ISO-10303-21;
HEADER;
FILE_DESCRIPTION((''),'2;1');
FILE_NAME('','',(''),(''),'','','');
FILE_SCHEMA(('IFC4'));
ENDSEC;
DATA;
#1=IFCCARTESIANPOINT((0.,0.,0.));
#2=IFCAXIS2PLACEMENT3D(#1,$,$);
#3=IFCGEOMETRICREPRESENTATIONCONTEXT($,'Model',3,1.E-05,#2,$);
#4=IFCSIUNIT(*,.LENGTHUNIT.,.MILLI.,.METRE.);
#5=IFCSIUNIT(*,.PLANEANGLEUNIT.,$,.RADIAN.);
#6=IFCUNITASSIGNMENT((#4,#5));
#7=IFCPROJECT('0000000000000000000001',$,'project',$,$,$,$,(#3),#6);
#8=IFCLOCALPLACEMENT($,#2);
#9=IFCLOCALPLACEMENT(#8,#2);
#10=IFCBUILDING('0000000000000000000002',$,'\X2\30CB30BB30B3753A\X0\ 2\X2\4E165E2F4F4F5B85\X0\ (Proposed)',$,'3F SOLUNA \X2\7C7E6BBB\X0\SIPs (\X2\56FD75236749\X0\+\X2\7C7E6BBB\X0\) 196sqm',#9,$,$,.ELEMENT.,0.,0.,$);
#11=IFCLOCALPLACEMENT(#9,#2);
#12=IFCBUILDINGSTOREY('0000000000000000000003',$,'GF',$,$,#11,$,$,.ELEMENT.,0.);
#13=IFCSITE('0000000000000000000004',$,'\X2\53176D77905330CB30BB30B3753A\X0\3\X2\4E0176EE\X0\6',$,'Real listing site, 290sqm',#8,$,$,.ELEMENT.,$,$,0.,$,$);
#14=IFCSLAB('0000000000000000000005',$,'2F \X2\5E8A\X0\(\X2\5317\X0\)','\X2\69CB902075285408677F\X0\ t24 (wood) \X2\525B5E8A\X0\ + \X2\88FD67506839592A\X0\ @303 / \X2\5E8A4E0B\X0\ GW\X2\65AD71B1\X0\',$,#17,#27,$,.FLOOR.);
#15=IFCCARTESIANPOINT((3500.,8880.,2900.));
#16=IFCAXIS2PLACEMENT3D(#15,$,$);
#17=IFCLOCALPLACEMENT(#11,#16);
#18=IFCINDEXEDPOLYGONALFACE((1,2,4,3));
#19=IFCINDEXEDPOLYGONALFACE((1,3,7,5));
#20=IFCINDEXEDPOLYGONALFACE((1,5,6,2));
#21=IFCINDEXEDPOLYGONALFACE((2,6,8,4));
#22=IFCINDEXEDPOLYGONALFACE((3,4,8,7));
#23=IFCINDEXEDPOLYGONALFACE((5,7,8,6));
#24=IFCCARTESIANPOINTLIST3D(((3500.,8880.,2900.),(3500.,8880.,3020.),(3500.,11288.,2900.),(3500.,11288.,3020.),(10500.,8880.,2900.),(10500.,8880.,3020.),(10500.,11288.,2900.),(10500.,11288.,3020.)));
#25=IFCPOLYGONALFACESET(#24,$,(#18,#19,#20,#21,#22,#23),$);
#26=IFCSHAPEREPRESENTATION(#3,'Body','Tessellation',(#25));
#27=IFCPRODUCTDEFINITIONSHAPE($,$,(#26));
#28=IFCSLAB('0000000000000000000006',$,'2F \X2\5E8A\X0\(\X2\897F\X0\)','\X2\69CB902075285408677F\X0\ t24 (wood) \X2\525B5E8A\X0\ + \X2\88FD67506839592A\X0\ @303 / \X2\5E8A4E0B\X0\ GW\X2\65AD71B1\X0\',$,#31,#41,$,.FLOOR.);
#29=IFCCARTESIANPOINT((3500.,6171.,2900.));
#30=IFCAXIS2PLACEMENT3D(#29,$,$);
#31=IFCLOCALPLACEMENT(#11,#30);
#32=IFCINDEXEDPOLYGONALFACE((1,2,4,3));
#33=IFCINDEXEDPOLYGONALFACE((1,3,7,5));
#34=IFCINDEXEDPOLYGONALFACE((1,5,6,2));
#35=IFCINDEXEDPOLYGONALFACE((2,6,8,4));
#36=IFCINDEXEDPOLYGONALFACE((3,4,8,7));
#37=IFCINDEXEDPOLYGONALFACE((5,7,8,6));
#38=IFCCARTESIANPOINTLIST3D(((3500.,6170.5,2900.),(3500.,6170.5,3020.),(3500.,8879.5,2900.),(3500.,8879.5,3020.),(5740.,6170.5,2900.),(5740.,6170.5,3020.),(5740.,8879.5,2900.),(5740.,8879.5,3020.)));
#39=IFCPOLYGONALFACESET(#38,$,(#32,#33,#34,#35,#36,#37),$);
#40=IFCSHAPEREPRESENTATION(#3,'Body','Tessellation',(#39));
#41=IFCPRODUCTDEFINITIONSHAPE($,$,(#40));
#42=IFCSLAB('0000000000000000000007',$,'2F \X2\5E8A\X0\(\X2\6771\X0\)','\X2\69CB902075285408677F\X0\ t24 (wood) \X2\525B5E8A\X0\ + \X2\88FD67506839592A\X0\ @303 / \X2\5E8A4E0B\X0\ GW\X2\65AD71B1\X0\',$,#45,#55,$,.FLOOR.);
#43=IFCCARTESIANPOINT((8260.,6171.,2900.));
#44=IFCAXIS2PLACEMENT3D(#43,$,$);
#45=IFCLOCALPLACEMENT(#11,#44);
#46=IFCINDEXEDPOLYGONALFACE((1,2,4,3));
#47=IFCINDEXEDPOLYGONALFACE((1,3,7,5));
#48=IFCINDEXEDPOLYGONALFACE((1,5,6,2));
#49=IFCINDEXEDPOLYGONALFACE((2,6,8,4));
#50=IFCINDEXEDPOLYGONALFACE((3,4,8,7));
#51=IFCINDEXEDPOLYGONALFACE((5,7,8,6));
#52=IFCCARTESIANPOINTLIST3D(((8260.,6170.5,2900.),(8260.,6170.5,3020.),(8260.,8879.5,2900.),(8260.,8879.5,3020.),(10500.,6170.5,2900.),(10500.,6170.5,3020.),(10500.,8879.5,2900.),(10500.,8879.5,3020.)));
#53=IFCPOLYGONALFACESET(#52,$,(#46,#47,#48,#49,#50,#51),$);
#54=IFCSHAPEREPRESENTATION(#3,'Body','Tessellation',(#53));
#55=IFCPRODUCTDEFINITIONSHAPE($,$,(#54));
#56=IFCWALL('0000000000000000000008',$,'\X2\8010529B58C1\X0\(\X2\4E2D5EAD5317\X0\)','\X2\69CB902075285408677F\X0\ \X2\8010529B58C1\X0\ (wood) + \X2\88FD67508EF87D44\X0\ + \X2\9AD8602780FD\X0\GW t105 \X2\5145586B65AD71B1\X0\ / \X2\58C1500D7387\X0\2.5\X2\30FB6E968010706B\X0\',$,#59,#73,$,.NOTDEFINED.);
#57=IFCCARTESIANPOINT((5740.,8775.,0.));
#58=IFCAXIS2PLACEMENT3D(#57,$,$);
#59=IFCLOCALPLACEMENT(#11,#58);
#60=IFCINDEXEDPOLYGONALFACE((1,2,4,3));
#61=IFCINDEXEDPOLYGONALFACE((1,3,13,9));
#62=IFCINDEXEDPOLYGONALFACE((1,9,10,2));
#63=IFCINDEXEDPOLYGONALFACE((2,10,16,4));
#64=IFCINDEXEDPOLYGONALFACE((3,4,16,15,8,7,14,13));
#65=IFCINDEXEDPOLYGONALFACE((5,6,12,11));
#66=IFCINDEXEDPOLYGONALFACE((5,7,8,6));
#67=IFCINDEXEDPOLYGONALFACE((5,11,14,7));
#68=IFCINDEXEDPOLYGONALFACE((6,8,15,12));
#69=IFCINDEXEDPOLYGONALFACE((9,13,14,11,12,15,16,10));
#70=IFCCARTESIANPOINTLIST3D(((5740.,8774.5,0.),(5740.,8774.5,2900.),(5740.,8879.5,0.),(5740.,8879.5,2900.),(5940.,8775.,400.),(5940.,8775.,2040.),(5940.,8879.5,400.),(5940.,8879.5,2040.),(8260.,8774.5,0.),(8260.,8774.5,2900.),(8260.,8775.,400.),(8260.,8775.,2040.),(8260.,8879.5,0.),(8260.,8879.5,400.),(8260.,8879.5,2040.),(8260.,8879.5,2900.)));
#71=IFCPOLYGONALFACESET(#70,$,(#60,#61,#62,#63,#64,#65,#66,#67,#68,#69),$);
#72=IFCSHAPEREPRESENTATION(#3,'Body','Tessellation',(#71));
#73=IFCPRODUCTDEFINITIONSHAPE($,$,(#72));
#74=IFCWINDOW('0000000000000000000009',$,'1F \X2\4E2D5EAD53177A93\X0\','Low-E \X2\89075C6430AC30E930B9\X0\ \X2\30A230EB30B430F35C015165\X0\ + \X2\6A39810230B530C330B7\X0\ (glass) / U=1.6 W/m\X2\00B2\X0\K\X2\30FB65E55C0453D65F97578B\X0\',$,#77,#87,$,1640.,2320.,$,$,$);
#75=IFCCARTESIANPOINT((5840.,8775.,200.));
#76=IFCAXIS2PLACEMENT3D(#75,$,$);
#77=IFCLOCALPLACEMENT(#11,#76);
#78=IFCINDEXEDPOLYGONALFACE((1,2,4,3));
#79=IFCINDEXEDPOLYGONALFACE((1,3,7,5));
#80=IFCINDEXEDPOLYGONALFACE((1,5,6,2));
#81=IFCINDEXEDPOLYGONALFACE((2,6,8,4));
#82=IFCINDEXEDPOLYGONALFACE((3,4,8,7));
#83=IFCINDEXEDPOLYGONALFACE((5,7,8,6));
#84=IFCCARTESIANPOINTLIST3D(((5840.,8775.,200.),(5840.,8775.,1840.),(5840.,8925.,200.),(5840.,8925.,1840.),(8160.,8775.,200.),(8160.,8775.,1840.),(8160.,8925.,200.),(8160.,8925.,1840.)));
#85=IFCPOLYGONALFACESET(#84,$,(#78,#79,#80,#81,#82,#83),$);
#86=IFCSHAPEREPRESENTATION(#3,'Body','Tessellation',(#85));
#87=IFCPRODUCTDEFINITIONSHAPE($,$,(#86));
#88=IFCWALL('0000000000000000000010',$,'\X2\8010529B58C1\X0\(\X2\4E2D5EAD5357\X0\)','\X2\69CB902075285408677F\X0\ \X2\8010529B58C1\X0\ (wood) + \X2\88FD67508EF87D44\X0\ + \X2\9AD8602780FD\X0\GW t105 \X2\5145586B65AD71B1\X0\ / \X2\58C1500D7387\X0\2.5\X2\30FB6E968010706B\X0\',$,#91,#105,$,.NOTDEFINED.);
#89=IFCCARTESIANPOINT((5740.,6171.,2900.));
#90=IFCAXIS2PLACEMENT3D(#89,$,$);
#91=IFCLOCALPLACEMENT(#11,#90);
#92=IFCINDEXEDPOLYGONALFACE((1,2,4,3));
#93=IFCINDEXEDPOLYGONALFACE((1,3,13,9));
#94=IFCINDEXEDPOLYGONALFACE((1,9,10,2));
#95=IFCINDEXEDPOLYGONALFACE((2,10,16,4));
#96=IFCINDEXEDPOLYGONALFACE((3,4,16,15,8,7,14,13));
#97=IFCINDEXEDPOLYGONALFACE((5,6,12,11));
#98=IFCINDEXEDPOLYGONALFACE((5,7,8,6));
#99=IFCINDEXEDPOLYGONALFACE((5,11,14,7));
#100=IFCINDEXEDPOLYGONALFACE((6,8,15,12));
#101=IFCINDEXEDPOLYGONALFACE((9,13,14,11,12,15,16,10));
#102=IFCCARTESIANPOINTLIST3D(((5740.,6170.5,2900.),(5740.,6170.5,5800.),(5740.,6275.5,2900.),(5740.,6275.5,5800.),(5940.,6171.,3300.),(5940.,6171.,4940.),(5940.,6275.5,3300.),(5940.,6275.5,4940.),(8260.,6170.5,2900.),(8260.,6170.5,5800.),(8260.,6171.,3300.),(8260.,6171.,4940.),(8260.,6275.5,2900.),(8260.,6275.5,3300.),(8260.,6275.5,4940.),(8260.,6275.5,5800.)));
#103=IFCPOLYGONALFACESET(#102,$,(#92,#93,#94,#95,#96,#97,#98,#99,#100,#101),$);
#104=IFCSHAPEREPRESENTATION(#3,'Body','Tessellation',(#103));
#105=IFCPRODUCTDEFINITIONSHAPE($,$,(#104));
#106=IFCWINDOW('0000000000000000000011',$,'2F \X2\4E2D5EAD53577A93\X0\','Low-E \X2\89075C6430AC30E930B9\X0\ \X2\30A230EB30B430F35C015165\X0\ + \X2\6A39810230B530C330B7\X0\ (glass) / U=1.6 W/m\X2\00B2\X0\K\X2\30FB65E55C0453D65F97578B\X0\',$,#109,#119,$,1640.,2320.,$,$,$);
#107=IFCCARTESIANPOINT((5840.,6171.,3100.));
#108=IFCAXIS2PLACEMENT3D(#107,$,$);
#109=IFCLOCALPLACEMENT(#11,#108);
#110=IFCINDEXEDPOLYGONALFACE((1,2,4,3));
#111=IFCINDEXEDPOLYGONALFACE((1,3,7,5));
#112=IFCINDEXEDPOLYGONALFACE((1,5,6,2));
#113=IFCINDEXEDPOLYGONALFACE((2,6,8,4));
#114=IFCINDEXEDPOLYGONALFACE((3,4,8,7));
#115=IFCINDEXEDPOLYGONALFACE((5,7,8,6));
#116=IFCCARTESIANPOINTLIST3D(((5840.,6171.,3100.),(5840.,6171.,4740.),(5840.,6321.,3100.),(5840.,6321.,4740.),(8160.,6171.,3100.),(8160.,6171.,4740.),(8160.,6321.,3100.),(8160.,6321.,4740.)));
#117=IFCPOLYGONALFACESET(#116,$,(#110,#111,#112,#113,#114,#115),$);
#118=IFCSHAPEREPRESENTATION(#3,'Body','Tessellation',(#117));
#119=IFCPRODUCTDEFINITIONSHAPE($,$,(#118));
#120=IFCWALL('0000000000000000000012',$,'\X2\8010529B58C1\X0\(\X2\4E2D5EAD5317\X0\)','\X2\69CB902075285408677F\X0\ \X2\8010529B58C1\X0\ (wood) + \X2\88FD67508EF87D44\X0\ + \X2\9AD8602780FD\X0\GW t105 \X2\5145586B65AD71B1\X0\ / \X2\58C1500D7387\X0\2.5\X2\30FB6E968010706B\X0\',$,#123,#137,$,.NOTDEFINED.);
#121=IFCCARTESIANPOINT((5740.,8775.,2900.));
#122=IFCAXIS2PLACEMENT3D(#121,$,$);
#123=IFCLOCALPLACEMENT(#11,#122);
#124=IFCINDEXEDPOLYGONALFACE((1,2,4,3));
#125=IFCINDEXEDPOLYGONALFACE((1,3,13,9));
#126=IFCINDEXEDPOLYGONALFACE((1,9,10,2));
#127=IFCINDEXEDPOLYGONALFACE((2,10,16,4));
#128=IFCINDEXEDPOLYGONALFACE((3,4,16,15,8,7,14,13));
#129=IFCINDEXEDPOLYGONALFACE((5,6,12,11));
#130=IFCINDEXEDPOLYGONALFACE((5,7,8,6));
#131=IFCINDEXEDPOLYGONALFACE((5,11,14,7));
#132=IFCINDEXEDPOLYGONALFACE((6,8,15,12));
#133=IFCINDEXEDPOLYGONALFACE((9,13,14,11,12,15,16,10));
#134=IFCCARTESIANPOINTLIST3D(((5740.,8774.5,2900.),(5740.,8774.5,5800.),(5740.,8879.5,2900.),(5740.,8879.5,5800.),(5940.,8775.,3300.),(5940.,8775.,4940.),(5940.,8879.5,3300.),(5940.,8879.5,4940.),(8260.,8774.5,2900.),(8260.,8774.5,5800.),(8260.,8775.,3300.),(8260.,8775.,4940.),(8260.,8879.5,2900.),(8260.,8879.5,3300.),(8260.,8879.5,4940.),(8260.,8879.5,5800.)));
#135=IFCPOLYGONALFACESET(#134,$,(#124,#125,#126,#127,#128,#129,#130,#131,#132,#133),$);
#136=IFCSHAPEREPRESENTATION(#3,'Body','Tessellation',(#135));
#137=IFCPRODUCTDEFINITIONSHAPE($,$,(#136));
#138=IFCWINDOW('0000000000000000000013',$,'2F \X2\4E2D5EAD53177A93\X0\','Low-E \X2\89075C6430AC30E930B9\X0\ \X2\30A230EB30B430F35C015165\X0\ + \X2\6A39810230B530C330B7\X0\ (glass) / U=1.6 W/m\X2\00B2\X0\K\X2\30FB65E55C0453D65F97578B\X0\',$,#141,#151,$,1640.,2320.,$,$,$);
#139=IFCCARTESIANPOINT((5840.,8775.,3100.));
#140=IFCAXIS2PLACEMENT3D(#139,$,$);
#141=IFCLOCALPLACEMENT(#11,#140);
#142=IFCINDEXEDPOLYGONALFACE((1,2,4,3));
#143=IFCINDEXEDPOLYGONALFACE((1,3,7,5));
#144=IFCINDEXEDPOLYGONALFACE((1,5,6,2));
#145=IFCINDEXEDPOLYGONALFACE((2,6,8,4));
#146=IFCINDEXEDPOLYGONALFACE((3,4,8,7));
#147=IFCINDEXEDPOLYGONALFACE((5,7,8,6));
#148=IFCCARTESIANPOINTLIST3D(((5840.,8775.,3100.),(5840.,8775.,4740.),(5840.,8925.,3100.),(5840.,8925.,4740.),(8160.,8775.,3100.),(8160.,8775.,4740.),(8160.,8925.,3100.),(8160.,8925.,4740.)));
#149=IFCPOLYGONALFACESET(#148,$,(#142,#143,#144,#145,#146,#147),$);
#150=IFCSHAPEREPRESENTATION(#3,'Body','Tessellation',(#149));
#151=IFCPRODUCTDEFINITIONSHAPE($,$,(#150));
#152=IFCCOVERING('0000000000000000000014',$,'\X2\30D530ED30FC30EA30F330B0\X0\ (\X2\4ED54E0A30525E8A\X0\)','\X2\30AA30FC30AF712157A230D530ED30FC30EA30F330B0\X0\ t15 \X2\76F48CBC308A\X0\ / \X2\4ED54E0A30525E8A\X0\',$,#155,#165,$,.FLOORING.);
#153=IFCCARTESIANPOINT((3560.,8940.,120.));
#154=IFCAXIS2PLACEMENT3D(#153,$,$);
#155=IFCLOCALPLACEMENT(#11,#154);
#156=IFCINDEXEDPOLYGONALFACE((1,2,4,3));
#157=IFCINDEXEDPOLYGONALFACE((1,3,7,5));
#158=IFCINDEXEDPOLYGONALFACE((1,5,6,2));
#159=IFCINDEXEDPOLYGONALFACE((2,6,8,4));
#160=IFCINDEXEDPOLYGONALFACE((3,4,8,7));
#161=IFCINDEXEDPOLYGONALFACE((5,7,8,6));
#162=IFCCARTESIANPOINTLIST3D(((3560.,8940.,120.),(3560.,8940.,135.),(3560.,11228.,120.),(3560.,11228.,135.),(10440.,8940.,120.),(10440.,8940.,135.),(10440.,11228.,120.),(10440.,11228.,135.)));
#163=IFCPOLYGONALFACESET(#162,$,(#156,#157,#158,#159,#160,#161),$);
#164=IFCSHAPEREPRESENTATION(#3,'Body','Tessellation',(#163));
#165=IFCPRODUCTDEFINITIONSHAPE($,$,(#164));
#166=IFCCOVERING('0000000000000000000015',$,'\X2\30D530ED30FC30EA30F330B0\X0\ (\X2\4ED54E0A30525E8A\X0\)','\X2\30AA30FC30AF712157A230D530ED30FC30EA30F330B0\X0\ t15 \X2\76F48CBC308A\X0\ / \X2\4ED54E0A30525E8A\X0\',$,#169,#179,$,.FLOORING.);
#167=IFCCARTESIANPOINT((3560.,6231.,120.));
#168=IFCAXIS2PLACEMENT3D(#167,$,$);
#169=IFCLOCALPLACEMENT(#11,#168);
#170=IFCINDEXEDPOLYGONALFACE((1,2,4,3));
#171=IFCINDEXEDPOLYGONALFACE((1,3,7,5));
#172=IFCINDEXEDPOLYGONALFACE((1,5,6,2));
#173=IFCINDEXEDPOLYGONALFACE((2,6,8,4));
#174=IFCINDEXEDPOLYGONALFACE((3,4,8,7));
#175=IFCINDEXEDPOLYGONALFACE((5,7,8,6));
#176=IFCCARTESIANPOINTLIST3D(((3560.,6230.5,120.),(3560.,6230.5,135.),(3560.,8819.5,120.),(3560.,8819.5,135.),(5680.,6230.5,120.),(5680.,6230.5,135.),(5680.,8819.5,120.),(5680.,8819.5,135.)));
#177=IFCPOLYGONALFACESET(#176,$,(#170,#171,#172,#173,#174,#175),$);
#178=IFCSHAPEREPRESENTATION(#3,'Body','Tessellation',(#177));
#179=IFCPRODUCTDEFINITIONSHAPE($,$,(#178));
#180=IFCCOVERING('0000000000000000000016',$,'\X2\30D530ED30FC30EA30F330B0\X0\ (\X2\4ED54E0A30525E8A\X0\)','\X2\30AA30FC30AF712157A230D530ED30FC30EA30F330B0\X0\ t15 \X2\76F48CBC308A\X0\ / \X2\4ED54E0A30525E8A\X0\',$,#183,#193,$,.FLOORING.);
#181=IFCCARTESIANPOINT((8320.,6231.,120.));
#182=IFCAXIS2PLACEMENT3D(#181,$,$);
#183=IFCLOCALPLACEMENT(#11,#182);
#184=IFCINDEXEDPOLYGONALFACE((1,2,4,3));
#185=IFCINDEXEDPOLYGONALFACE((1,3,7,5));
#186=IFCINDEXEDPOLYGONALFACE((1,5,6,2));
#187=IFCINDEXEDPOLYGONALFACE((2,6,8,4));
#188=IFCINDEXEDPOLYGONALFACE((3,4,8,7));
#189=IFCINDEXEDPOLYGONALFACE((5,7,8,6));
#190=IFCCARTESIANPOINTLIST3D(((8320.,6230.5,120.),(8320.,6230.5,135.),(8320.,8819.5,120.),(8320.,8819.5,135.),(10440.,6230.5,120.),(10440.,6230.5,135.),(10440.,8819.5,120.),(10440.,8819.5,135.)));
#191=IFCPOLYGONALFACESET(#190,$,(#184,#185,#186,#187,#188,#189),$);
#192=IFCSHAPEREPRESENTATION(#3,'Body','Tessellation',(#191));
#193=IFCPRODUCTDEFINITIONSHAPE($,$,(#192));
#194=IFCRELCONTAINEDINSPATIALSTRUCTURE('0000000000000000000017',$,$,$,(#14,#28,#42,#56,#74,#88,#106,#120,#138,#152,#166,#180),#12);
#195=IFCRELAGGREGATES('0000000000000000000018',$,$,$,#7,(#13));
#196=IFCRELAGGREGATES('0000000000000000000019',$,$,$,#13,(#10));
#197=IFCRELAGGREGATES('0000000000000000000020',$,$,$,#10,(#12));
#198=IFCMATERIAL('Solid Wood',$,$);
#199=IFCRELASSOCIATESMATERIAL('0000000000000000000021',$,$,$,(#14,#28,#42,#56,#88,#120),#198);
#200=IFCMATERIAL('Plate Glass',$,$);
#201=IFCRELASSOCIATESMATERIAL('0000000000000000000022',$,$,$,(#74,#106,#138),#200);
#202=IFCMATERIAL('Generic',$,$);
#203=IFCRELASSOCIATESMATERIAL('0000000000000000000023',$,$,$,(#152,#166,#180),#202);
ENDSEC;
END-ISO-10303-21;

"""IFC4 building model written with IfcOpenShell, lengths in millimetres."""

from ifc_helpers import new_model, si_unit, frame, frame_2d, origin, place, context, project, spatial, rectangle, extrude, material, element, fill, save


model = new_model("IFC4")

# Units and contexts
model_context = context("Model", 3, precision=1e-05, world=origin())
ifc_project = project(units=[si_unit("LENGTHUNIT", "METRE", prefix="MILLI"), si_unit("PLANEANGLEUNIT", "RADIAN")], contexts=[model_context])

# Site, building, storey
site_placement = place(None, origin())
site = spatial("IfcSite", under=ifc_project, at=site_placement, Name="北海道ニセコ町3丁目6", ObjectType="Real listing site, 290sqm", CompositionType="ELEMENT", RefElevation=0.0)
building_placement = place(site_placement, origin())
building = spatial("IfcBuilding", under=site, at=building_placement, Name="ニセコ町 2世帯住宅 (Proposed)", ObjectType="3F SOLUNA 籾殻SIPs (国産杉+籾殻) 196sqm", CompositionType="ELEMENT", ElevationOfRefHeight=0.0, ElevationOfTerrain=0.0)
storey_placement = place(building_placement, origin())
storey = spatial("IfcBuildingStorey", under=building, at=storey_placement, Name="GF", CompositionType="ELEMENT", Elevation=0.0)

# Slabs
ifc_material_1 = material(Name="Solid Wood")
slab_1_placement = place(storey_placement, frame((3500.0, 8880.0, 2900.0)))
element("IfcSlab", 1, at=slab_1_placement, inside=storey, material=ifc_material_1, Name="2F 床(北)", Description="構造用合板 t24 (wood) 剛床 + 製材根太 @303 / 床下 GW断熱", PredefinedType="FLOOR", context=model_context, shape_type="SweptSolid", body=[
    extrude(rectangle(XDim=7000.0, YDim=2408.0, at=frame_2d((3500.0, 1204.0))), frame((3500.0, 8880.0, 2900.0)), (0.0, 0.0, 1.0), 120.0),
])
slab_2_placement = place(storey_placement, frame((3500.0, 6171.0, 2900.0)))
element("IfcSlab", 2, at=slab_2_placement, inside=storey, material=ifc_material_1, Name="2F 床(西)", Description="構造用合板 t24 (wood) 剛床 + 製材根太 @303 / 床下 GW断熱", PredefinedType="FLOOR", context=model_context, shape_type="SweptSolid", body=[
    extrude(rectangle(XDim=2240.0, YDim=2709.0, at=frame_2d((1120.0, 1354.0))), frame((3500.0, 6171.0, 2900.0)), (0.0, 0.0, 1.0), 120.0),
])
slab_3_placement = place(storey_placement, frame((8260.0, 6171.0, 2900.0)))
element("IfcSlab", 3, at=slab_3_placement, inside=storey, material=ifc_material_1, Name="2F 床(東)", Description="構造用合板 t24 (wood) 剛床 + 製材根太 @303 / 床下 GW断熱", PredefinedType="FLOOR", context=model_context, shape_type="SweptSolid", body=[
    extrude(rectangle(XDim=2240.0, YDim=2709.0, at=frame_2d((1120.0, 1354.0))), frame((8260.0, 6171.0, 2900.0)), (0.0, 0.0, 1.0), 120.0),
])

# Wall, opening, window
wall_1_placement = place(storey_placement, frame((5740.0, 8775.0, 0.0)))
wall_1 = element("IfcWall", 4, at=wall_1_placement, inside=storey, material=ifc_material_1, Name="耐力壁(中庭北)", Description="構造用合板 耐力壁 (wood) + 製材軸組 + 高性能GW t105 充填断熱 / 壁倍率2.5・準耐火", PredefinedType="NOTDEFINED", context=model_context, shape_type="SweptSolid", body=[
    extrude(rectangle(XDim=2520.0, YDim=105.0, at=frame_2d((1260.0, 52.0))), frame((5740.0, 8775.0, 0.0)), (0.0, 0.0, 1.0), 2900.0),
])
opening_1_placement = place(storey_placement, frame((5840.0, 8775.0, 200.0)))
opening_1 = element("IfcOpeningElement", 5, at=opening_1_placement, cuts=wall_1, PredefinedType="NOTDEFINED", context=model_context, shape_type="SweptSolid", body=[
    extrude(rectangle(XDim=2320.0, YDim=150.0, at=frame_2d((1160.0, 75.0))), frame((5840.0, 8775.0, 200.0)), (0.0, 0.0, 1.0), 1640.0),
])
ifc_material_2 = material(Name="Plate Glass")
window_1_placement = place(storey_placement, frame((5840.0, 8775.0, 200.0)))
window_1 = element("IfcWindow", 6, at=window_1_placement, inside=storey, material=ifc_material_2, Name="1F 中庭北窓", Description="Low-E 複層ガラス アルゴン封入 + 樹脂サッシ (glass) / U=1.6 W/m²K・日射取得型", OverallHeight=1640.0, OverallWidth=2320.0, context=model_context, shape_type="SweptSolid", body=[
    extrude(rectangle(XDim=2320.0, YDim=150.0, at=frame_2d((1160.0, 75.0))), frame((5840.0, 8775.0, 200.0)), (0.0, 0.0, 1.0), 1640.0),
])
fill(opening_1, window_1)

# Walls, openings, windows
wall_2_placement = place(storey_placement, frame((5740.0, 6171.0, 2900.0)))
wall_2 = element("IfcWall", 7, at=wall_2_placement, inside=storey, material=ifc_material_1, Name="耐力壁(中庭南)", Description="構造用合板 耐力壁 (wood) + 製材軸組 + 高性能GW t105 充填断熱 / 壁倍率2.5・準耐火", PredefinedType="NOTDEFINED", context=model_context, shape_type="SweptSolid", body=[
    extrude(rectangle(XDim=2520.0, YDim=105.0, at=frame_2d((1260.0, 52.0))), frame((5740.0, 6171.0, 2900.0)), (0.0, 0.0, 1.0), 2900.0),
])
opening_2_placement = place(storey_placement, frame((5840.0, 6171.0, 3100.0)))
opening_2 = element("IfcOpeningElement", 8, at=opening_2_placement, cuts=wall_2, PredefinedType="NOTDEFINED", context=model_context, shape_type="SweptSolid", body=[
    extrude(rectangle(XDim=2320.0, YDim=150.0, at=frame_2d((1160.0, 75.0))), frame((5840.0, 6171.0, 3100.0)), (0.0, 0.0, 1.0), 1640.0),
])
window_2_placement = place(storey_placement, frame((5840.0, 6171.0, 3100.0)))
window_2 = element("IfcWindow", 9, at=window_2_placement, inside=storey, material=ifc_material_2, Name="2F 中庭南窓", Description="Low-E 複層ガラス アルゴン封入 + 樹脂サッシ (glass) / U=1.6 W/m²K・日射取得型", OverallHeight=1640.0, OverallWidth=2320.0, context=model_context, shape_type="SweptSolid", body=[
    extrude(rectangle(XDim=2320.0, YDim=150.0, at=frame_2d((1160.0, 75.0))), frame((5840.0, 6171.0, 3100.0)), (0.0, 0.0, 1.0), 1640.0),
])
fill(opening_2, window_2)
wall_3_placement = place(storey_placement, frame((5740.0, 8775.0, 2900.0)))
wall_3 = element("IfcWall", 10, at=wall_3_placement, inside=storey, material=ifc_material_1, Name="耐力壁(中庭北)", Description="構造用合板 耐力壁 (wood) + 製材軸組 + 高性能GW t105 充填断熱 / 壁倍率2.5・準耐火", PredefinedType="NOTDEFINED", context=model_context, shape_type="SweptSolid", body=[
    extrude(rectangle(XDim=2520.0, YDim=105.0, at=frame_2d((1260.0, 52.0))), frame((5740.0, 8775.0, 2900.0)), (0.0, 0.0, 1.0), 2900.0),
])
opening_3_placement = place(storey_placement, frame((5840.0, 8775.0, 3100.0)))
opening_3 = element("IfcOpeningElement", 11, at=opening_3_placement, cuts=wall_3, PredefinedType="NOTDEFINED", context=model_context, shape_type="SweptSolid", body=[
    extrude(rectangle(XDim=2320.0, YDim=150.0, at=frame_2d((1160.0, 75.0))), frame((5840.0, 8775.0, 3100.0)), (0.0, 0.0, 1.0), 1640.0),
])
window_3_placement = place(storey_placement, frame((5840.0, 8775.0, 3100.0)))
window_3 = element("IfcWindow", 12, at=window_3_placement, inside=storey, material=ifc_material_2, Name="2F 中庭北窓", Description="Low-E 複層ガラス アルゴン封入 + 樹脂サッシ (glass) / U=1.6 W/m²K・日射取得型", OverallHeight=1640.0, OverallWidth=2320.0, context=model_context, shape_type="SweptSolid", body=[
    extrude(rectangle(XDim=2320.0, YDim=150.0, at=frame_2d((1160.0, 75.0))), frame((5840.0, 8775.0, 3100.0)), (0.0, 0.0, 1.0), 1640.0),
])
fill(opening_3, window_3)

# Coverings
ifc_material_3 = material(Name="Generic")
covering_1_placement = place(storey_placement, frame((3560.0, 8940.0, 120.0)))
element("IfcCovering", 13, at=covering_1_placement, inside=storey, material=ifc_material_3, Name="フローリング (仕上げ床)", Description="オーク無垢フローリング t15 直貼り / 仕上げ床", PredefinedType="FLOORING", context=model_context, shape_type="SweptSolid", body=[
    extrude(rectangle(XDim=6880.0, YDim=2288.0, at=frame_2d((3440.0, 1144.0))), frame((3560.0, 8940.0, 120.0)), (0.0, 0.0, 1.0), 15.0),
])
covering_2_placement = place(storey_placement, frame((3560.0, 6231.0, 120.0)))
element("IfcCovering", 14, at=covering_2_placement, inside=storey, material=ifc_material_3, Name="フローリング (仕上げ床)", Description="オーク無垢フローリング t15 直貼り / 仕上げ床", PredefinedType="FLOORING", context=model_context, shape_type="SweptSolid", body=[
    extrude(rectangle(XDim=2120.0, YDim=2589.0, at=frame_2d((1060.0, 1294.0))), frame((3560.0, 6231.0, 120.0)), (0.0, 0.0, 1.0), 15.0),
])
covering_3_placement = place(storey_placement, frame((8320.0, 6231.0, 120.0)))
element("IfcCovering", 15, at=covering_3_placement, inside=storey, material=ifc_material_3, Name="フローリング (仕上げ床)", Description="オーク無垢フローリング t15 直貼り / 仕上げ床", PredefinedType="FLOORING", context=model_context, shape_type="SweptSolid", body=[
    extrude(rectangle(XDim=2120.0, YDim=2589.0, at=frame_2d((1060.0, 1294.0))), frame((8320.0, 6231.0, 120.0)), (0.0, 0.0, 1.0), 15.0),
])

save(model, "model.ifc")
